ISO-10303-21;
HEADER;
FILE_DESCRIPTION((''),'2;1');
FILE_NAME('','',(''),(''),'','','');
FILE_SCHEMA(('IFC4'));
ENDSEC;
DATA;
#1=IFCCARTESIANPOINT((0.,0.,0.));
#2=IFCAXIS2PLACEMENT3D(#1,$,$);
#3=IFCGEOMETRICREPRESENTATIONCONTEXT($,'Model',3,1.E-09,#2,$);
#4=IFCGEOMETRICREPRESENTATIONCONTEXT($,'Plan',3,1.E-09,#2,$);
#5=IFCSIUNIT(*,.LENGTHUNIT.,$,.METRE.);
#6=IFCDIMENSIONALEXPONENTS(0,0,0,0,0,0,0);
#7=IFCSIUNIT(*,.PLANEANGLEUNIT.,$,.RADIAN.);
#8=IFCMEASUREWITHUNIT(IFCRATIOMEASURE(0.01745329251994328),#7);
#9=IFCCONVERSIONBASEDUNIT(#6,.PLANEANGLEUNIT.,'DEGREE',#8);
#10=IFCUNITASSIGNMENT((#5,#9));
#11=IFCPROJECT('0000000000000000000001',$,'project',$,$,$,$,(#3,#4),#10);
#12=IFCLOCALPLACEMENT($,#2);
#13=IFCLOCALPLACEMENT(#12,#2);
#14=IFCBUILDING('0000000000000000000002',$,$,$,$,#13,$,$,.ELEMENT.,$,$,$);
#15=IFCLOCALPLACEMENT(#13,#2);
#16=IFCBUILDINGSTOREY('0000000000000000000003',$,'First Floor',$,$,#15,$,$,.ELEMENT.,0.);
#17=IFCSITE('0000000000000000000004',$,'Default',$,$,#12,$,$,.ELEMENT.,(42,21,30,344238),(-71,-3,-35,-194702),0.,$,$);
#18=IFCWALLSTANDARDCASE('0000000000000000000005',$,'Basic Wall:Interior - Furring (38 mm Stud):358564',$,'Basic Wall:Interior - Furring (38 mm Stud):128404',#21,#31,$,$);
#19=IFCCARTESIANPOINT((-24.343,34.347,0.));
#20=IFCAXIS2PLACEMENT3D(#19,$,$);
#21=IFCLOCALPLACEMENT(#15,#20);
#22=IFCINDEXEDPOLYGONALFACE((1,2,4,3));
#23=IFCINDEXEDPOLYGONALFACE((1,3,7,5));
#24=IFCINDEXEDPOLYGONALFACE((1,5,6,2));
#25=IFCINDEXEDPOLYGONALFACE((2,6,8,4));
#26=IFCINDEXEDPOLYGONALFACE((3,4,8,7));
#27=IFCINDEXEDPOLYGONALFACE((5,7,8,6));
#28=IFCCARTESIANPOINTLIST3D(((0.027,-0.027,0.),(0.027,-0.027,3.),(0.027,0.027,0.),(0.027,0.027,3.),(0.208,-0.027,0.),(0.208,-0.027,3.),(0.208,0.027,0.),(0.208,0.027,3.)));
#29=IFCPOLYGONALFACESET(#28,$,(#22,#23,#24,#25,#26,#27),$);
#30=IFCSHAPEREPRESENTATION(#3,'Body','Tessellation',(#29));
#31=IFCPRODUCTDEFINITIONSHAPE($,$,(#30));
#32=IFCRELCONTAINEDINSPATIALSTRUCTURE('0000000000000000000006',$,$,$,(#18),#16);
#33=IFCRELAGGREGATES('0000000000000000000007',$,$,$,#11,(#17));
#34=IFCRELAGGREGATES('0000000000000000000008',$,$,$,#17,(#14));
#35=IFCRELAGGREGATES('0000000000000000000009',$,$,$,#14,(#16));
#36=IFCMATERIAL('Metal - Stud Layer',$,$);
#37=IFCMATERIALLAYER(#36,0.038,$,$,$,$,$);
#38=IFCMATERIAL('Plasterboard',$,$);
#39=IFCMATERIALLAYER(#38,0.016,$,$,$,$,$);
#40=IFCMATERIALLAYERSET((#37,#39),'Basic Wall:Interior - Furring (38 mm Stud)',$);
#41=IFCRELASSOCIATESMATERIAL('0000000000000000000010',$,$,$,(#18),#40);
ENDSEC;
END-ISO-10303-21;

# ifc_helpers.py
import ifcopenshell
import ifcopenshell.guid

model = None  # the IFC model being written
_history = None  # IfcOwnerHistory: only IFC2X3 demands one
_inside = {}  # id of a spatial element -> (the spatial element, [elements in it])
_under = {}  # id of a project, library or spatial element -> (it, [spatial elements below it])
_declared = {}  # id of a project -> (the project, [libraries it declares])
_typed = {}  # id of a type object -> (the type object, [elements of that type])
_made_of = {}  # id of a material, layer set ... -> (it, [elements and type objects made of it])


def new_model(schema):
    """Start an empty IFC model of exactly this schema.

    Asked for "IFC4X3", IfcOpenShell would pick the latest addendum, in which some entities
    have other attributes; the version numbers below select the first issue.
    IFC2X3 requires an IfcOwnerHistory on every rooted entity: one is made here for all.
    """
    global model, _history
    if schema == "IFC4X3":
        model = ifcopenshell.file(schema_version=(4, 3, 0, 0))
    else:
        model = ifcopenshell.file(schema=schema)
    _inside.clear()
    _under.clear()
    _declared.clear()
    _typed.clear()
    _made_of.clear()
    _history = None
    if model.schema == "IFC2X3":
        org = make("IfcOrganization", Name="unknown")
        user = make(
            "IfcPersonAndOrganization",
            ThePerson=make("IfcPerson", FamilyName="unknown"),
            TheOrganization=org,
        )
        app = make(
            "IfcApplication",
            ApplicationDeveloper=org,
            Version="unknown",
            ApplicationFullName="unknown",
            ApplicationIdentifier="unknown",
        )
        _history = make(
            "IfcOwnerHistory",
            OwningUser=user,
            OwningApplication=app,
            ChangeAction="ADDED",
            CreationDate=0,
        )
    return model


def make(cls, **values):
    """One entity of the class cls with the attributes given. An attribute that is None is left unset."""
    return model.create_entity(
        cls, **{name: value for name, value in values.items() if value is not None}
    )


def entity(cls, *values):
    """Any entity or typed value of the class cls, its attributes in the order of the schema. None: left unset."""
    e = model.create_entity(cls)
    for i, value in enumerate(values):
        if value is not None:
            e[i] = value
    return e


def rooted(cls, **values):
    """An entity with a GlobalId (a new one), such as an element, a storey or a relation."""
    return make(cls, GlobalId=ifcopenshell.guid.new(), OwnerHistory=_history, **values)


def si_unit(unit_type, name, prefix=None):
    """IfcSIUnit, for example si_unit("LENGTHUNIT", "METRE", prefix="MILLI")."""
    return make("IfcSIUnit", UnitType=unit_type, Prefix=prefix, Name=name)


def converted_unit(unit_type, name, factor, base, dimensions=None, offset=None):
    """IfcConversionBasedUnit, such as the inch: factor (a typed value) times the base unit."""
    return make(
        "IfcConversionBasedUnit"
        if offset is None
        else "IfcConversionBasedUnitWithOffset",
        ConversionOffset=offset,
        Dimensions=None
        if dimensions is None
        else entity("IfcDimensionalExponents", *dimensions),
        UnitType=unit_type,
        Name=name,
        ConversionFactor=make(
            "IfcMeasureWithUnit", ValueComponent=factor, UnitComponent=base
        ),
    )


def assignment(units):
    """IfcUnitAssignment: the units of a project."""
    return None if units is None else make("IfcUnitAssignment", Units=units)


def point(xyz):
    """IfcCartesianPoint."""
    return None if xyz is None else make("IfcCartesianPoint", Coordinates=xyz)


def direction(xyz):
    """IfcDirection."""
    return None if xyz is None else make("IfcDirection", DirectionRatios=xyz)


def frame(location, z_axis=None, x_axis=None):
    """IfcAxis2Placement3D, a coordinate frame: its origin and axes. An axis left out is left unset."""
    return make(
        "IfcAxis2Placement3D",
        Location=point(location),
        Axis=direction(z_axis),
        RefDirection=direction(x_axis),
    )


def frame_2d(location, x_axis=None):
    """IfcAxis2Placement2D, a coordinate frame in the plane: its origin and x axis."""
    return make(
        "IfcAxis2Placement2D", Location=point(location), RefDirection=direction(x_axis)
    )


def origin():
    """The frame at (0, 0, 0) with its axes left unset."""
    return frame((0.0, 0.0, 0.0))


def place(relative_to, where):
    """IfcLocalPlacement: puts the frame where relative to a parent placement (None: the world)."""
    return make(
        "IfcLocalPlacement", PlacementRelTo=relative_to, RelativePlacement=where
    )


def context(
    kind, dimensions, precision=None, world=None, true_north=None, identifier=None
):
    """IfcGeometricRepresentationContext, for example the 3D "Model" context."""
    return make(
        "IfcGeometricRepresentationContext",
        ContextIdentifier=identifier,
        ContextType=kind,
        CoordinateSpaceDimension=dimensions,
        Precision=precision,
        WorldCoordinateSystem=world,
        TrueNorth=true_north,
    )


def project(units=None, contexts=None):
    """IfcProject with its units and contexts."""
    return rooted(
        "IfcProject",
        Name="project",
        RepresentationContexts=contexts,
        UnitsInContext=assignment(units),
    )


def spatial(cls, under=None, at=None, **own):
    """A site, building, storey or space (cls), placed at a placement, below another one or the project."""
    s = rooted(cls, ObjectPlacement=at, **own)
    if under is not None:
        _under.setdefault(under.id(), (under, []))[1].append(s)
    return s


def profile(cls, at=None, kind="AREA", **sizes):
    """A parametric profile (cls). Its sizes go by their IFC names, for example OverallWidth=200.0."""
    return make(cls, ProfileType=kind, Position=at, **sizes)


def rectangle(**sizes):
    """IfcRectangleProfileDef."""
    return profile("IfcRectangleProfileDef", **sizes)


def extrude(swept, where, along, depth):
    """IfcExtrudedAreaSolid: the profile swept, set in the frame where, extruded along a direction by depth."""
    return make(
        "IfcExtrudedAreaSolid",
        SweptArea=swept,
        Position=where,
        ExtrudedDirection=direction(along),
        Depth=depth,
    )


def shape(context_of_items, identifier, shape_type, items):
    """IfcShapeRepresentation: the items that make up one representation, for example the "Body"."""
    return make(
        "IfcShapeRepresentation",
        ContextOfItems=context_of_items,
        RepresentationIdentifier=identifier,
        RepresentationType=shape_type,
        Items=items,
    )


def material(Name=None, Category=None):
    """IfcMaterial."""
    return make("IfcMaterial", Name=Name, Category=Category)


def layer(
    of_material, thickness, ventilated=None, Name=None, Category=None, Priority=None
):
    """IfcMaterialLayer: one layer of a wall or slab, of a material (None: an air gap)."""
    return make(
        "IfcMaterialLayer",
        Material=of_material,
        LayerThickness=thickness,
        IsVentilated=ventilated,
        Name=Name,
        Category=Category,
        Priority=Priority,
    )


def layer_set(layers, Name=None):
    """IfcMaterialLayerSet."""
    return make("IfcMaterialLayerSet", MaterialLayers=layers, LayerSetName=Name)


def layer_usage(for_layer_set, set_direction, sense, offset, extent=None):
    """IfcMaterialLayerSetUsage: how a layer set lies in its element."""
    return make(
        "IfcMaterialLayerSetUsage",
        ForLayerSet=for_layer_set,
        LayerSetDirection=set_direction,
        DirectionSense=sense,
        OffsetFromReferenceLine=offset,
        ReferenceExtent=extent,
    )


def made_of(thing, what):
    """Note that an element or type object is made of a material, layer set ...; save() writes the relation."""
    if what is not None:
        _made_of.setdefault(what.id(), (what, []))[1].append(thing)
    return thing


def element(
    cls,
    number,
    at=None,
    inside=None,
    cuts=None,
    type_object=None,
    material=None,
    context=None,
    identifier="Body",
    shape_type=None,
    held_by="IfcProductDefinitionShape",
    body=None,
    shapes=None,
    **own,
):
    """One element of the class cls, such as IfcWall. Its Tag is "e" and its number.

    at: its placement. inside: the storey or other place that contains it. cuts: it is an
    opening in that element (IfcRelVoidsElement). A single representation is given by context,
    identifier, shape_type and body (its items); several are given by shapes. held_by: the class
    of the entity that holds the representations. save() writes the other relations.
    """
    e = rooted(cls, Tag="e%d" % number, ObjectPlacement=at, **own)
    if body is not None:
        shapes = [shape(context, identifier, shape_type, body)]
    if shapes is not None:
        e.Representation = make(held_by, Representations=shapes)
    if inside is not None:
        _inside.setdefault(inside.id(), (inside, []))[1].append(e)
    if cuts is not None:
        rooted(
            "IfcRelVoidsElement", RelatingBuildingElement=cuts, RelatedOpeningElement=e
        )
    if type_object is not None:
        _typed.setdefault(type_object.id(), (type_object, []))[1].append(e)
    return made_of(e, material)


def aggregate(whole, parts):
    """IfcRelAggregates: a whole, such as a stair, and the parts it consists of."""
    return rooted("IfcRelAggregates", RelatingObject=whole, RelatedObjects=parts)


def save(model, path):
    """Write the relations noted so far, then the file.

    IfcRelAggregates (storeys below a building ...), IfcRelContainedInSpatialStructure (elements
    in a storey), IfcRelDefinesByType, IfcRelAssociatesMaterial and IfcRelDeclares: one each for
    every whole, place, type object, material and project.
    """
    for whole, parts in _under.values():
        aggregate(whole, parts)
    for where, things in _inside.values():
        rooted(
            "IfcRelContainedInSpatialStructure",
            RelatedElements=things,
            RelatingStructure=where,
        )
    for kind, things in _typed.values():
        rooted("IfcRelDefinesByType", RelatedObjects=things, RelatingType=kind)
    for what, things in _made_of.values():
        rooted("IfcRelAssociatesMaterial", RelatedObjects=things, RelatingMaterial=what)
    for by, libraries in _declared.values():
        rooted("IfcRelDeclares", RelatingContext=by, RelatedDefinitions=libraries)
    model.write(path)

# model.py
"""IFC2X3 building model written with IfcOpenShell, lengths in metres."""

from ifc_helpers import new_model, entity, si_unit, converted_unit, frame, frame_2d, origin, place, context, project, spatial, rectangle, extrude, material, layer, layer_set, layer_usage, element, save


model = new_model("IFC2X3")

# Units and contexts
model_context = context("Model", 3, precision=1e-09, world=origin())
plan_context = context("Plan", 3, precision=1e-09, world=origin())
ifc_project = project(units=[si_unit("LENGTHUNIT", "METRE"), converted_unit("PLANEANGLEUNIT", "DEGREE", entity("IfcRatioMeasure", 0.01745329251994328), si_unit("PLANEANGLEUNIT", "RADIAN"), dimensions=[0, 0, 0, 0, 0, 0, 0])], contexts=[model_context, plan_context])

# Site, building, storey
site_placement = place(None, origin())
site = spatial("IfcSite", under=ifc_project, at=site_placement, Name="Default", CompositionType="ELEMENT", RefLatitude=(42, 21, 30, 344238), RefLongitude=(-71, -3, -35, -194702), RefElevation=0.0)
building_placement = place(site_placement, origin())
building = spatial("IfcBuilding", under=site, at=building_placement, CompositionType="ELEMENT")
storey_placement = place(building_placement, origin())
storey = spatial("IfcBuildingStorey", under=building, at=storey_placement, Name="First Floor", CompositionType="ELEMENT", Elevation=0.0)

# Shared definitions
ifc_material_1 = material(Name="Plasterboard")
ifc_layer_1 = layer(ifc_material_1, 0.016)
ifc_material_2 = material(Name="Metal - Stud Layer")

# Shared definitions
ifc_layer_2 = layer(ifc_material_2, 0.038)
ifc_layer_set_1 = layer_set([ifc_layer_2, ifc_layer_1], Name="Basic Wall:Interior - Furring (38 mm Stud)")
ifc_layer_usage_1 = layer_usage(ifc_layer_set_1, "AXIS2", "NEGATIVE", 0.027)

# Wall
wall_1_placement = place(storey_placement, frame((-24.343, 34.347, 0.0)))
element("IfcWallStandardCase", 1, at=wall_1_placement, inside=storey, material=ifc_layer_usage_1, Name="Basic Wall:Interior - Furring (38 mm Stud):358564", ObjectType="Basic Wall:Interior - Furring (38 mm Stud):128404", context=model_context, shape_type="SweptSolid", body=[
    extrude(rectangle(XDim=0.181, YDim=0.054, at=frame_2d((0.1175, 0.0), x_axis=(-1.0, 0.0))), origin(), (0.0, 0.0, 1.0), 3.0),
])

save(model, "model.ifc")
